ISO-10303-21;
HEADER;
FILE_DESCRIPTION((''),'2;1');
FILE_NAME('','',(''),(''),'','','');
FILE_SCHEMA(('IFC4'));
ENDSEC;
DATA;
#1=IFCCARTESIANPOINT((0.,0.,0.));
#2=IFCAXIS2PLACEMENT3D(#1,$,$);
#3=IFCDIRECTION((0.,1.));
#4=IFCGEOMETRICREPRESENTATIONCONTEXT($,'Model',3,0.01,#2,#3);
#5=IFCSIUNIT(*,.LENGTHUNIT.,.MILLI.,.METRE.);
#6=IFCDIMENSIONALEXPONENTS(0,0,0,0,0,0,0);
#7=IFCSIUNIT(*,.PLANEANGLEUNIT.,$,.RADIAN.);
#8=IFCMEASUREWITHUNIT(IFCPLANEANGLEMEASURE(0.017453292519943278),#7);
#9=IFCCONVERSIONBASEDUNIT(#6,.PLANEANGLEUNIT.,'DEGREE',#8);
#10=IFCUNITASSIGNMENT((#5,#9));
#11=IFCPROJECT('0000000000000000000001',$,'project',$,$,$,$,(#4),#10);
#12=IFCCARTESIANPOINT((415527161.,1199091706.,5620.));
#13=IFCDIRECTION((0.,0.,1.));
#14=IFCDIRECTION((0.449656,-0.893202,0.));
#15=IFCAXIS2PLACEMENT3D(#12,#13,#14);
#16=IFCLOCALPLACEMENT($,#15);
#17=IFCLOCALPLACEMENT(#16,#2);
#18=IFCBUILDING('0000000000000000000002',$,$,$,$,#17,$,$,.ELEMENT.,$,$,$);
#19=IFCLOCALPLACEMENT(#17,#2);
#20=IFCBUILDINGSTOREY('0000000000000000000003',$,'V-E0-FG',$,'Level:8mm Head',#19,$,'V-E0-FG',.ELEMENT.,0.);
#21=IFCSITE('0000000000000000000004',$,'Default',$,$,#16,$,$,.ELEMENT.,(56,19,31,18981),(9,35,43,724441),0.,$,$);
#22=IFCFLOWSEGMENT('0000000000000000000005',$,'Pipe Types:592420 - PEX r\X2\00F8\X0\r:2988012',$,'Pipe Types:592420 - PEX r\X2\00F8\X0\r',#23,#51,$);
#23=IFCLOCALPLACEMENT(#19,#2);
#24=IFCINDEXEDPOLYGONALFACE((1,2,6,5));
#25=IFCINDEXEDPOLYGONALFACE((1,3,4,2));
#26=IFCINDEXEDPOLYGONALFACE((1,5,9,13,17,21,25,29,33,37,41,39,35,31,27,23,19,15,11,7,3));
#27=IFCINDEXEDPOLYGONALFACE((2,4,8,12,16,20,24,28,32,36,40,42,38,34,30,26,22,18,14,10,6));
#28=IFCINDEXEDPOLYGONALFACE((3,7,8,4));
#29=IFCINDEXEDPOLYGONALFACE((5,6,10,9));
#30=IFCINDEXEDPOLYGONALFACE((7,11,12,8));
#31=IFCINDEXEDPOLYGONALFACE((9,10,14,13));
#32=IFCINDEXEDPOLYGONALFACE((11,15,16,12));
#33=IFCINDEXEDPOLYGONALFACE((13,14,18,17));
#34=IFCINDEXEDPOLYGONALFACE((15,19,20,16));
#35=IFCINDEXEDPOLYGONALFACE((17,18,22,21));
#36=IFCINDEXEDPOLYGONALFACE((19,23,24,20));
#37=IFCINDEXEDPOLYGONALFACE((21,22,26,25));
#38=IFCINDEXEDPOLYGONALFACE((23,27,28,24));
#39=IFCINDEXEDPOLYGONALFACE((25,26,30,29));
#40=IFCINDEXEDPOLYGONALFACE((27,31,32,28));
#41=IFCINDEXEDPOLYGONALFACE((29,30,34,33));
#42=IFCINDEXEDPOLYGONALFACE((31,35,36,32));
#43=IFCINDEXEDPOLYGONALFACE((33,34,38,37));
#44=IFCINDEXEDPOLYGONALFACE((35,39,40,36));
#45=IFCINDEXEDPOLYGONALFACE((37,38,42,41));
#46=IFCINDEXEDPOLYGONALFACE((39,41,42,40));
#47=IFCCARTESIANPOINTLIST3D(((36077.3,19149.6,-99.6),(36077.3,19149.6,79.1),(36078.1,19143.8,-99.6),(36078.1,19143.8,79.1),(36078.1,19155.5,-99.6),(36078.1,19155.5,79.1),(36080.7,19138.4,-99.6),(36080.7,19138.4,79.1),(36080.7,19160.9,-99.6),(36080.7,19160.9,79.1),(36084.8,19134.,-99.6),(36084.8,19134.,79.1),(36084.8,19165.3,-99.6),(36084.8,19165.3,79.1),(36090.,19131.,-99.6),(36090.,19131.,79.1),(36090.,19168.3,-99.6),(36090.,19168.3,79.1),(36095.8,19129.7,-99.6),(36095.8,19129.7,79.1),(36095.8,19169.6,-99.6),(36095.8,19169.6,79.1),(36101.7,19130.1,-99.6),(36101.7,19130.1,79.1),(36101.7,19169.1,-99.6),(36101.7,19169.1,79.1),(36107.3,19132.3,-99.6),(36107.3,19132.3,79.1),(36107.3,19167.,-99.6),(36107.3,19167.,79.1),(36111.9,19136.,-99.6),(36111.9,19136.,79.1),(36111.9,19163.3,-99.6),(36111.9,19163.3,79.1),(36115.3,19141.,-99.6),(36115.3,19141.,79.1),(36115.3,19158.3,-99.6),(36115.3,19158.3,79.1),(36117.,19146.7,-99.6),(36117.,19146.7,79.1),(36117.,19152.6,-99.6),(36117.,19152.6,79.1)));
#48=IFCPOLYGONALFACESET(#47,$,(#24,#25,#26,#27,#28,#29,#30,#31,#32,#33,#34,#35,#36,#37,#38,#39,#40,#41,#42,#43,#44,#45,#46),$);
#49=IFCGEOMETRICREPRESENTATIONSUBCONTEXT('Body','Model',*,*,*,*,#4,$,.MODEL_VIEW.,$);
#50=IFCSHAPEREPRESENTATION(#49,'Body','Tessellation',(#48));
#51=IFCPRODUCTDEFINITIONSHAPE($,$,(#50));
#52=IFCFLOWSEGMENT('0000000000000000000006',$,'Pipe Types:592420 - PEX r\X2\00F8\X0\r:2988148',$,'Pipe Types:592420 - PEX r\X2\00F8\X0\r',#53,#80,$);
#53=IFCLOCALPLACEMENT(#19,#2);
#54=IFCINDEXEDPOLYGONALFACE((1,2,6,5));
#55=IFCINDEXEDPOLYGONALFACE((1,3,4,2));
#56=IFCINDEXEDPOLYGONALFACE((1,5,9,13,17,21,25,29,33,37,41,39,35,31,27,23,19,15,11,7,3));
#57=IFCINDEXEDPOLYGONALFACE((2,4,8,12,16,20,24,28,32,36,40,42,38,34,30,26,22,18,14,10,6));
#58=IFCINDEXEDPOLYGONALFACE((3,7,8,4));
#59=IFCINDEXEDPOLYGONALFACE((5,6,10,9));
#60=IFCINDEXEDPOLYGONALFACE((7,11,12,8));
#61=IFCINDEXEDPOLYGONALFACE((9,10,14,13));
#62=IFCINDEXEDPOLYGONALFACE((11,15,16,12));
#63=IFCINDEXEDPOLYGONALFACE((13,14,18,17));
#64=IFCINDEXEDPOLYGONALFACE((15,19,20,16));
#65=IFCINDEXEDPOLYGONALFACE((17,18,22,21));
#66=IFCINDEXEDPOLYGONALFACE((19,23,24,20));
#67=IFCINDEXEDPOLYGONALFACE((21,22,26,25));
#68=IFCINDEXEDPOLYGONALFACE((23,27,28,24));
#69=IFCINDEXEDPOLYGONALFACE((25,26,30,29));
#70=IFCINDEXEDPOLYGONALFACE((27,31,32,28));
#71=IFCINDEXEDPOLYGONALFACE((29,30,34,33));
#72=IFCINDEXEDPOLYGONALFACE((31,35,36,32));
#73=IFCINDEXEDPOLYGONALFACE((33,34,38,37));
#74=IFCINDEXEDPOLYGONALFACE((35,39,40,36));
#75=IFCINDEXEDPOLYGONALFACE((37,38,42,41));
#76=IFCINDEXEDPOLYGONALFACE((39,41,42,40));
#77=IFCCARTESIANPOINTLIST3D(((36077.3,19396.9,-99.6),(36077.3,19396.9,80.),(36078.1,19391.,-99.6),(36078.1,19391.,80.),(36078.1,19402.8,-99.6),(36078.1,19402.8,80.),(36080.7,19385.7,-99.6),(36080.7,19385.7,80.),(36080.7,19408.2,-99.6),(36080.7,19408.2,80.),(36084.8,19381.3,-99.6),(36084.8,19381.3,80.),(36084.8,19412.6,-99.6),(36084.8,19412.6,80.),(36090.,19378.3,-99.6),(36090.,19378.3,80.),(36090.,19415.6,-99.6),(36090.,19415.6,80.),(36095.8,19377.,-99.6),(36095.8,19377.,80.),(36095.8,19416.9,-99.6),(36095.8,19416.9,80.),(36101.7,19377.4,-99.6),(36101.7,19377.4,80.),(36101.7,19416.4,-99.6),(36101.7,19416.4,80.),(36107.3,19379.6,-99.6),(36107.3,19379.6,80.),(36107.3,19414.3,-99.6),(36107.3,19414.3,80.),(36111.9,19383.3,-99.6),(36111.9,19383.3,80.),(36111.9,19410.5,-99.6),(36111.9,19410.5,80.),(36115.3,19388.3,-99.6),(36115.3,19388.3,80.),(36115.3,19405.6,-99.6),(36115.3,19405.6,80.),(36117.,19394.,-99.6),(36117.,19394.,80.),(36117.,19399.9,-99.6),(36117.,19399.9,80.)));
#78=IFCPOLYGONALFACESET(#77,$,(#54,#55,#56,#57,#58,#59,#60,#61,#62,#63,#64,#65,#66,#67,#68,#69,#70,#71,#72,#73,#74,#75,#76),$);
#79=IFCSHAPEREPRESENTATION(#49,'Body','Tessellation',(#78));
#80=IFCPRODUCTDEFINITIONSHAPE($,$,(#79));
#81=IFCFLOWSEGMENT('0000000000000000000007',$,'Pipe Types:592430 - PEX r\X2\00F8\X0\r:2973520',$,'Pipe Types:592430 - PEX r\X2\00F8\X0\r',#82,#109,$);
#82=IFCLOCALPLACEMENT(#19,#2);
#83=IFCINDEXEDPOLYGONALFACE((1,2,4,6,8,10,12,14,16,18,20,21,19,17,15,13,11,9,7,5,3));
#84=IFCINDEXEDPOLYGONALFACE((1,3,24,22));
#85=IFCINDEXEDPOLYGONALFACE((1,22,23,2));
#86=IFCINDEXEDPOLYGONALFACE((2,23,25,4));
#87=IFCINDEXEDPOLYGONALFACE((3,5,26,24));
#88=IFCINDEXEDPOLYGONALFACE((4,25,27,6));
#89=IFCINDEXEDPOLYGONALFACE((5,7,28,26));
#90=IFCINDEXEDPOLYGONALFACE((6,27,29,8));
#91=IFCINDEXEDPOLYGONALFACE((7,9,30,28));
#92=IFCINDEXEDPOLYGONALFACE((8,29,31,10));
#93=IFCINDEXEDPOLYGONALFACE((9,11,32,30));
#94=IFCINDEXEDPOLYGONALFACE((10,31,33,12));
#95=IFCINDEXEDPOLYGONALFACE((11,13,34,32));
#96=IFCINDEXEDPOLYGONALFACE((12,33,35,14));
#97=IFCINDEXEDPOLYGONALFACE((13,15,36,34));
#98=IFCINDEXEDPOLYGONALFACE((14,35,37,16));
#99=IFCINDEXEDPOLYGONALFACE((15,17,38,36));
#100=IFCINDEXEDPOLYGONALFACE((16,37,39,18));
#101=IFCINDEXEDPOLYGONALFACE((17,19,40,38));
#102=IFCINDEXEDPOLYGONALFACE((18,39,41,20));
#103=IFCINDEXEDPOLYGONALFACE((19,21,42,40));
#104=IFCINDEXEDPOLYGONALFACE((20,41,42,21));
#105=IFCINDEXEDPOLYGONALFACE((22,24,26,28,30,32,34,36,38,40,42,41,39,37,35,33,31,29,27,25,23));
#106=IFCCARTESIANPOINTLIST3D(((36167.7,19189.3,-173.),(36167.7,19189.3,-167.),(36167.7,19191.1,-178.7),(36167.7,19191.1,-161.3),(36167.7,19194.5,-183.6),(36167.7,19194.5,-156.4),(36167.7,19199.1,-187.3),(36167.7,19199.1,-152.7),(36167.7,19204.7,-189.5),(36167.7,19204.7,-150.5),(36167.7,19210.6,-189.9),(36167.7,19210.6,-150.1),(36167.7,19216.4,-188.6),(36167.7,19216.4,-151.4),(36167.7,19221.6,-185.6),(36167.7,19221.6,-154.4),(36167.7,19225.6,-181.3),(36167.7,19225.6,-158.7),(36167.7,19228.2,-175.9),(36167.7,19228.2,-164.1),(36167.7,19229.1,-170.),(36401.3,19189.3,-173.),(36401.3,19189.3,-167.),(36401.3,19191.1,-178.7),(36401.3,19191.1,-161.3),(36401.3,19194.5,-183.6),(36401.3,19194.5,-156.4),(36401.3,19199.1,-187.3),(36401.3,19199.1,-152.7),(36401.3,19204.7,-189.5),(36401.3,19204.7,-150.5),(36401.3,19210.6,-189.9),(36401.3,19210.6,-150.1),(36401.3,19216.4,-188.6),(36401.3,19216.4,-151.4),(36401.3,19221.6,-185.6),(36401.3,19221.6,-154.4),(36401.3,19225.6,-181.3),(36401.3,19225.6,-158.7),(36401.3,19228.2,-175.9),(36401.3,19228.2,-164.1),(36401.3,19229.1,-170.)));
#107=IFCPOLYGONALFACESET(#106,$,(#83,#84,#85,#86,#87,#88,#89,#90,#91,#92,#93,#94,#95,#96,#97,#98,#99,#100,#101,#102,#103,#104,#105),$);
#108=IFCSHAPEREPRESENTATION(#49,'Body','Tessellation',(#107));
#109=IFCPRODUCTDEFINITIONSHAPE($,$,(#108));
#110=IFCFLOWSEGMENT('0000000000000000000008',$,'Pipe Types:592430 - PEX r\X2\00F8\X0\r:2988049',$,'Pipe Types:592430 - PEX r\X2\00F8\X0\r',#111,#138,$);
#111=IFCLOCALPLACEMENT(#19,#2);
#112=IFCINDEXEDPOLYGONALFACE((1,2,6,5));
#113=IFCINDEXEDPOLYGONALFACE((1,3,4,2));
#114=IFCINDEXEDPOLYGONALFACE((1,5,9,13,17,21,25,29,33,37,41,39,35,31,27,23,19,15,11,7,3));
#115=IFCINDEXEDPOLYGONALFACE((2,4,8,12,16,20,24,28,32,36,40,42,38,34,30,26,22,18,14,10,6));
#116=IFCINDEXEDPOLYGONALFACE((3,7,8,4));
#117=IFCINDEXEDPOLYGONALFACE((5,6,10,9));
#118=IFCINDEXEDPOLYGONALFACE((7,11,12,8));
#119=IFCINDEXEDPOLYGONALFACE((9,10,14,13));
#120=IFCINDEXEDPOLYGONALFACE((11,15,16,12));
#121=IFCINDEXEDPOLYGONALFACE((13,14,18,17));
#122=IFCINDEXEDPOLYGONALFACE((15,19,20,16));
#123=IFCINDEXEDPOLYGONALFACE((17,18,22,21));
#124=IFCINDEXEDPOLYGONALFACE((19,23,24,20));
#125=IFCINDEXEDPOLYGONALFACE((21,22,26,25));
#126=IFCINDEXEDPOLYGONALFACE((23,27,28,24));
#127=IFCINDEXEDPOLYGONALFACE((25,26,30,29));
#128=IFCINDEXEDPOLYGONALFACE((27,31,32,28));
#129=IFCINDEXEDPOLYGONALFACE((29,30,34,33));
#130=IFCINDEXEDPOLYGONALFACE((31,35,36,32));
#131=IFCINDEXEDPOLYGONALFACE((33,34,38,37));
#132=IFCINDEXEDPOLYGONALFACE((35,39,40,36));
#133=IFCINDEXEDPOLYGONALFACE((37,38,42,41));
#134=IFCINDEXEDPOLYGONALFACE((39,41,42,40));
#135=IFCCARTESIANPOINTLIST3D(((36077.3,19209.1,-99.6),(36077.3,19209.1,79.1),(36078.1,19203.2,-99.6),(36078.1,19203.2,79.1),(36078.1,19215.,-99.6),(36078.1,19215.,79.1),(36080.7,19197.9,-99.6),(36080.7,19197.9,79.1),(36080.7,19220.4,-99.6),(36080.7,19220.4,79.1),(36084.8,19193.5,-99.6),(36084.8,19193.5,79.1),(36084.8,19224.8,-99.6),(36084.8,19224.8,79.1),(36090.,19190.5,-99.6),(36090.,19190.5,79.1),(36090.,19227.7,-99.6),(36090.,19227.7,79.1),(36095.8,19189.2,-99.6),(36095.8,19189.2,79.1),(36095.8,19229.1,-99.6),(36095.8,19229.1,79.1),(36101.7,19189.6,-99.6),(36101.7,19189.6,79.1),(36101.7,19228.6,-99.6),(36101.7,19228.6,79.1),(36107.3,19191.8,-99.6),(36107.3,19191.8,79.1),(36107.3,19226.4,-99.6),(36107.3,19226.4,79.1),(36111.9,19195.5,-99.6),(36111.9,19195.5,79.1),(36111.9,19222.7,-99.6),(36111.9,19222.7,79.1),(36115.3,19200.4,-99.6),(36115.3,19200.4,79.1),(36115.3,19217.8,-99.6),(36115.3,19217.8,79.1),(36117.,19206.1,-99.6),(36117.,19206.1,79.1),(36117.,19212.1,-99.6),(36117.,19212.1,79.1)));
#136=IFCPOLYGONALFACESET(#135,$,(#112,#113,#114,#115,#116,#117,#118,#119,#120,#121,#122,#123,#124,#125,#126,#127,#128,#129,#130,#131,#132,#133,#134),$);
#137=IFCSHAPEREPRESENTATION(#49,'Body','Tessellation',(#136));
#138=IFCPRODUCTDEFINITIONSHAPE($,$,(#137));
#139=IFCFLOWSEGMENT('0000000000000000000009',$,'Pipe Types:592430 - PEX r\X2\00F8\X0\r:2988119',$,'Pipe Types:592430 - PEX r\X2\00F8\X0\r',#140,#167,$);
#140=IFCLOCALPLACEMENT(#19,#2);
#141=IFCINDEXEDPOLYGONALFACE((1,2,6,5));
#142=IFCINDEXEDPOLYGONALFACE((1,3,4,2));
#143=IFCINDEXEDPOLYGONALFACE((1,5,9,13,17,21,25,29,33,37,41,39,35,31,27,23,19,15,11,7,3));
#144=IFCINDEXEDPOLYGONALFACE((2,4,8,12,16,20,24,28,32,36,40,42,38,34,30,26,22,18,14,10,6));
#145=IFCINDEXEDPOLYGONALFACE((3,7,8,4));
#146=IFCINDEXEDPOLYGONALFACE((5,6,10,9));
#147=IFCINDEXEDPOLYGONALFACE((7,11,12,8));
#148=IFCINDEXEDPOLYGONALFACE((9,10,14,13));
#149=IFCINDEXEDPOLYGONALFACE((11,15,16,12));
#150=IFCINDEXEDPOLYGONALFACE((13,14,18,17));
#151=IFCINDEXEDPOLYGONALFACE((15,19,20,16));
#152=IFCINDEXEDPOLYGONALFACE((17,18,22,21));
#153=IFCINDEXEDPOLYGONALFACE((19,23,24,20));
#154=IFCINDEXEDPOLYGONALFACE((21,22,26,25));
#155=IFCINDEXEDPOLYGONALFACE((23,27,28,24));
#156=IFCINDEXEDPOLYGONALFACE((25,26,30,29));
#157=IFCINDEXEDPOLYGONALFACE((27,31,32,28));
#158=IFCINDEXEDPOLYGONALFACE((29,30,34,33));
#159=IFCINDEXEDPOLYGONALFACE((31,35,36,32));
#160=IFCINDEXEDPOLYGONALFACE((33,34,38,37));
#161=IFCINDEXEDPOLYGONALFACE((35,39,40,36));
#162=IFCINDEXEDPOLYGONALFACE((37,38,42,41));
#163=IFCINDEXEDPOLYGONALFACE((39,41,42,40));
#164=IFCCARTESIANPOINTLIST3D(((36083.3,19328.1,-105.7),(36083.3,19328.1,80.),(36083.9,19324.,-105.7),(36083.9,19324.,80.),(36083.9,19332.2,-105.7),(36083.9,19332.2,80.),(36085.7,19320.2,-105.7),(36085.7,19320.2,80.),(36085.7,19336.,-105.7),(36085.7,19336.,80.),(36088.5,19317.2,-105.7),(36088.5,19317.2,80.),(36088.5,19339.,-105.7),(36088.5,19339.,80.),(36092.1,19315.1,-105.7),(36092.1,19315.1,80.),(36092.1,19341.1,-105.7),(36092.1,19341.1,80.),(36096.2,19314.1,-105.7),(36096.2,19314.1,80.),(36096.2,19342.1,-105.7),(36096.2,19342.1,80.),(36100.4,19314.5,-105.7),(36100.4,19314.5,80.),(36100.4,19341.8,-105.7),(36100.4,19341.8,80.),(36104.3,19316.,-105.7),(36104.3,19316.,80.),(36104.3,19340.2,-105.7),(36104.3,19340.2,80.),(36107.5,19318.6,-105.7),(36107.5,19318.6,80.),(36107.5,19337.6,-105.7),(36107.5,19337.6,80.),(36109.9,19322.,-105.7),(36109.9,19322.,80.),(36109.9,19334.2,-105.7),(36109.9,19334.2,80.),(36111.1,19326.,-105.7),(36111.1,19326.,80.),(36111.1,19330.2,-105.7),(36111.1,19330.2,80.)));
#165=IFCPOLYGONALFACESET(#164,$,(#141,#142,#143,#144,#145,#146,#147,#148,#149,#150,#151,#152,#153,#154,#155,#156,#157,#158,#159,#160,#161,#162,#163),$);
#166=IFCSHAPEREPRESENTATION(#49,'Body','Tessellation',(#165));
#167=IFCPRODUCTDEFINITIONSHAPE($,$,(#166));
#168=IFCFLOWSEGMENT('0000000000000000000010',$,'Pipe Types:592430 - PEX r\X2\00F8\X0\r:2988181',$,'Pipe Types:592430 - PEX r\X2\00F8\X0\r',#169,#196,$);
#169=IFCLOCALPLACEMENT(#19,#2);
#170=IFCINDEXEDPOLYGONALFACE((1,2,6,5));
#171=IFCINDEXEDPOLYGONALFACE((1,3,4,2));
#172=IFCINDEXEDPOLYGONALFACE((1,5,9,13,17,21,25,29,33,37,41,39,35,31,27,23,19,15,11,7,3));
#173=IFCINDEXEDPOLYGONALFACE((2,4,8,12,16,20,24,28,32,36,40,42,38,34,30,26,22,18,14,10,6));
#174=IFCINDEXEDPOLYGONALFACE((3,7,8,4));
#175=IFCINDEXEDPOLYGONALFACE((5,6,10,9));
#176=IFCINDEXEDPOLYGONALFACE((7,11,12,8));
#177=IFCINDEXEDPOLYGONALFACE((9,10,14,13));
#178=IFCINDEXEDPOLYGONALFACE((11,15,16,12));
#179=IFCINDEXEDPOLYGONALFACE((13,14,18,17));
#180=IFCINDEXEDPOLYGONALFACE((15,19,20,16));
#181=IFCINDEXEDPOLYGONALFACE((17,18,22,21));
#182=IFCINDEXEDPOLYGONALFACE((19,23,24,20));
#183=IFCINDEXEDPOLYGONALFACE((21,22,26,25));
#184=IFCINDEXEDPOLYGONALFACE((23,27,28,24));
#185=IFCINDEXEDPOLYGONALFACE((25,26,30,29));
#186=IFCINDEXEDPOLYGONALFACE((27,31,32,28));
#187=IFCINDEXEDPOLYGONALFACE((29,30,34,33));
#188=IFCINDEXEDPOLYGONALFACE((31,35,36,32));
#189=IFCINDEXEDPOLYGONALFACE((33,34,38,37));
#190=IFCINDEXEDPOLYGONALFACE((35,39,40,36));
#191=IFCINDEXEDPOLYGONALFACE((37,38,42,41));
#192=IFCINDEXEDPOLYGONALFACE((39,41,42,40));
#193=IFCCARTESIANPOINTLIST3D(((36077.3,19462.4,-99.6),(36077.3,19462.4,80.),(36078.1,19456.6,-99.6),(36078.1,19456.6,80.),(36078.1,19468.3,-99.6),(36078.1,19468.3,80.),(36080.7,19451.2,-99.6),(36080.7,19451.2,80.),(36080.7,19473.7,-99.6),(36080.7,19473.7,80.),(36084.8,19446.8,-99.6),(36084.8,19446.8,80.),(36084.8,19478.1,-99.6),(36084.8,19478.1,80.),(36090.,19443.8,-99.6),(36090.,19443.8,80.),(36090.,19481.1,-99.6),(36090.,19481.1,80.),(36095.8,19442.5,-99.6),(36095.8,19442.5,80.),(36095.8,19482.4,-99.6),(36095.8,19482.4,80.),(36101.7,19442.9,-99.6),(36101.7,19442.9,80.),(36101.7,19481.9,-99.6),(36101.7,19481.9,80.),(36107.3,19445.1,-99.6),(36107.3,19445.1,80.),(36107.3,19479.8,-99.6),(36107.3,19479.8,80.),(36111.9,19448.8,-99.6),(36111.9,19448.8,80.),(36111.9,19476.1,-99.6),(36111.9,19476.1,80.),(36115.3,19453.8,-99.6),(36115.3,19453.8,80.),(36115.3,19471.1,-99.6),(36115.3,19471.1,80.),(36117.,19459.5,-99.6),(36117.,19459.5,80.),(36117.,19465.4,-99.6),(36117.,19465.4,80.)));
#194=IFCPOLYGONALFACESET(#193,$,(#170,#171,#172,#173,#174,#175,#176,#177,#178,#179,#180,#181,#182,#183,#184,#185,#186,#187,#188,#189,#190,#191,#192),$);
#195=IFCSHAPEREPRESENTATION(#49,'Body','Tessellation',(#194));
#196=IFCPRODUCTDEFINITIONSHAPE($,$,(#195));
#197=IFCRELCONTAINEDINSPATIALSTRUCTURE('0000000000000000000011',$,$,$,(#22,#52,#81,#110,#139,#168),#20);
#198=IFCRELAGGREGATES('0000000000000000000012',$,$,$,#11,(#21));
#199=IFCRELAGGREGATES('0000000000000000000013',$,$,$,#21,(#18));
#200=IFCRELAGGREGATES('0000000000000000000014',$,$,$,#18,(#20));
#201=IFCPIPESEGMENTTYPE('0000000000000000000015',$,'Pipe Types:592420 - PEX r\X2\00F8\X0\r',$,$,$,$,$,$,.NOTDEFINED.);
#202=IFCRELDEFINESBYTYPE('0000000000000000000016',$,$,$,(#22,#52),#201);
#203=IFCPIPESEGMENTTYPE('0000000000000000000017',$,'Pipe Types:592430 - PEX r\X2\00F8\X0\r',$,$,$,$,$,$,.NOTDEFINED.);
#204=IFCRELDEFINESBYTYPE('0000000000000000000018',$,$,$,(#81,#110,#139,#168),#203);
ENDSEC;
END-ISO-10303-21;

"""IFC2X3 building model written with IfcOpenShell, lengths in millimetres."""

from ifc_helpers import new_model, entity, si_unit, converted_unit, direction, frame, frame_2d, origin, origin_2d_with_axis, place, context, subcontext, project, spatial, circle, extrude, type_object, element, save


model = new_model("IFC2X3")

# Units and contexts
model_context = context("Model", 3, precision=0.01, world=origin(), true_north=direction((0.0, 1.0)))
body_context = subcontext(model_context, "Body", "Model", "MODEL_VIEW")
ifc_project = project(units=[si_unit("LENGTHUNIT", "METRE", prefix="MILLI"), converted_unit("PLANEANGLEUNIT", "DEGREE", entity("IfcPlaneAngleMeasure", 0.017453292519943278), si_unit("PLANEANGLEUNIT", "RADIAN"), dimensions=[0, 0, 0, 0, 0, 0, 0])], contexts=[model_context])

# Site, building, storey
site_placement = place(None, frame((415527161.0, 1199091706.0, 5620.0), z_axis=(0.0, 0.0, 1.0), x_axis=(0.449656, -0.893202, 0.0)))
site = spatial("IfcSite", under=ifc_project, at=site_placement, Name="Default", CompositionType="ELEMENT", RefLatitude=(56, 19, 31, 18981), RefLongitude=(9, 35, 43, 724441), RefElevation=0.0)
building_placement = place(site_placement, origin())
building = spatial("IfcBuilding", under=site, at=building_placement, CompositionType="ELEMENT")
storey_placement = place(building_placement, origin())
storey = spatial("IfcBuildingStorey", under=building, at=storey_placement, Name="V-E0-FG", ObjectType="Level:8mm Head", LongName="V-E0-FG", CompositionType="ELEMENT", Elevation=0.0)

# Flow segments
pipe_segment_type_1 = type_object("IfcPipeSegmentType", Name="Pipe Types:592420 - PEX rør", PredefinedType="NOTDEFINED")
flow_segment_1_placement = place(storey_placement, origin())
element("IfcFlowSegment", 1, at=flow_segment_1_placement, inside=storey, type_object=pipe_segment_type_1, Name="Pipe Types:592420 - PEX rør:2988012", ObjectType="Pipe Types:592420 - PEX rør", context=body_context, shape_type="SweptSolid", body=[
    extrude(circle(Radius=20.0, at=origin_2d_with_axis()), frame((36097.3, 19149.6, -99.6), z_axis=(0.0, 0.0, 1.0), x_axis=(-1.0, 0.0, 0.0)), (0.0, 0.0, 1.0), 178.7),
])
flow_segment_2_placement = place(storey_placement, origin())
element("IfcFlowSegment", 2, at=flow_segment_2_placement, inside=storey, type_object=pipe_segment_type_1, Name="Pipe Types:592420 - PEX rør:2988148", ObjectType="Pipe Types:592420 - PEX rør", context=body_context, shape_type="SweptSolid", body=[
    extrude(circle(Radius=20.0, at=origin_2d_with_axis()), frame((36097.3, 19396.9, -99.6), z_axis=(0.0, 0.0, 1.0), x_axis=(-1.0, 0.0, 0.0)), (0.0, 0.0, 1.0), 179.6),
])
pipe_segment_type_2 = type_object("IfcPipeSegmentType", Name="Pipe Types:592430 - PEX rør", PredefinedType="NOTDEFINED")
flow_segment_3_placement = place(storey_placement, origin())
element("IfcFlowSegment", 3, at=flow_segment_3_placement, inside=storey, type_object=pipe_segment_type_2, Name="Pipe Types:592430 - PEX rør:2973520", ObjectType="Pipe Types:592430 - PEX rør", context=body_context, shape_type="SweptSolid", body=[
    extrude(circle(Radius=20.0, at=frame_2d((0.0, 0.0), x_axis=(1.0, 0.0))), frame((36167.7, 19209.1, -170.0), z_axis=(1.0, 0.0, 0.0), x_axis=(0.0, 1.0, 0.0)), (0.0, 0.0, 1.0), 233.7),
])
flow_segment_4_placement = place(storey_placement, origin())
element("IfcFlowSegment", 4, at=flow_segment_4_placement, inside=storey, type_object=pipe_segment_type_2, Name="Pipe Types:592430 - PEX rør:2988049", ObjectType="Pipe Types:592430 - PEX rør", context=body_context, shape_type="SweptSolid", body=[
    extrude(circle(Radius=20.0, at=origin_2d_with_axis()), frame((36097.3, 19209.1, -99.6), z_axis=(0.0, 0.0, 1.0), x_axis=(-1.0, 0.0, 0.0)), (0.0, 0.0, 1.0), 178.7),
])
flow_segment_5_placement = place(storey_placement, origin())
element("IfcFlowSegment", 5, at=flow_segment_5_placement, inside=storey, type_object=pipe_segment_type_2, Name="Pipe Types:592430 - PEX rør:2988119", ObjectType="Pipe Types:592430 - PEX rør", context=body_context, shape_type="SweptSolid", body=[
    extrude(circle(Radius=14.0, at=frame_2d((0.0, 0.0), x_axis=(1.0, 0.0))), frame((36097.3, 19328.1, -105.7), z_axis=(0.0, 0.0, 1.0), x_axis=(-1.0, 0.0, 0.0)), (0.0, 0.0, 1.0), 185.7),
])
flow_segment_6_placement = place(storey_placement, origin())
element("IfcFlowSegment", 6, at=flow_segment_6_placement, inside=storey, type_object=pipe_segment_type_2, Name="Pipe Types:592430 - PEX rør:2988181", ObjectType="Pipe Types:592430 - PEX rør", context=body_context, shape_type="SweptSolid", body=[
    extrude(circle(Radius=20.0, at=origin_2d_with_axis()), frame((36097.3, 19462.4, -99.6), z_axis=(0.0, 0.0, 1.0), x_axis=(-1.0, 0.0, 0.0)), (0.0, 0.0, 1.0), 179.6),
])

save(model, "model.ifc")
